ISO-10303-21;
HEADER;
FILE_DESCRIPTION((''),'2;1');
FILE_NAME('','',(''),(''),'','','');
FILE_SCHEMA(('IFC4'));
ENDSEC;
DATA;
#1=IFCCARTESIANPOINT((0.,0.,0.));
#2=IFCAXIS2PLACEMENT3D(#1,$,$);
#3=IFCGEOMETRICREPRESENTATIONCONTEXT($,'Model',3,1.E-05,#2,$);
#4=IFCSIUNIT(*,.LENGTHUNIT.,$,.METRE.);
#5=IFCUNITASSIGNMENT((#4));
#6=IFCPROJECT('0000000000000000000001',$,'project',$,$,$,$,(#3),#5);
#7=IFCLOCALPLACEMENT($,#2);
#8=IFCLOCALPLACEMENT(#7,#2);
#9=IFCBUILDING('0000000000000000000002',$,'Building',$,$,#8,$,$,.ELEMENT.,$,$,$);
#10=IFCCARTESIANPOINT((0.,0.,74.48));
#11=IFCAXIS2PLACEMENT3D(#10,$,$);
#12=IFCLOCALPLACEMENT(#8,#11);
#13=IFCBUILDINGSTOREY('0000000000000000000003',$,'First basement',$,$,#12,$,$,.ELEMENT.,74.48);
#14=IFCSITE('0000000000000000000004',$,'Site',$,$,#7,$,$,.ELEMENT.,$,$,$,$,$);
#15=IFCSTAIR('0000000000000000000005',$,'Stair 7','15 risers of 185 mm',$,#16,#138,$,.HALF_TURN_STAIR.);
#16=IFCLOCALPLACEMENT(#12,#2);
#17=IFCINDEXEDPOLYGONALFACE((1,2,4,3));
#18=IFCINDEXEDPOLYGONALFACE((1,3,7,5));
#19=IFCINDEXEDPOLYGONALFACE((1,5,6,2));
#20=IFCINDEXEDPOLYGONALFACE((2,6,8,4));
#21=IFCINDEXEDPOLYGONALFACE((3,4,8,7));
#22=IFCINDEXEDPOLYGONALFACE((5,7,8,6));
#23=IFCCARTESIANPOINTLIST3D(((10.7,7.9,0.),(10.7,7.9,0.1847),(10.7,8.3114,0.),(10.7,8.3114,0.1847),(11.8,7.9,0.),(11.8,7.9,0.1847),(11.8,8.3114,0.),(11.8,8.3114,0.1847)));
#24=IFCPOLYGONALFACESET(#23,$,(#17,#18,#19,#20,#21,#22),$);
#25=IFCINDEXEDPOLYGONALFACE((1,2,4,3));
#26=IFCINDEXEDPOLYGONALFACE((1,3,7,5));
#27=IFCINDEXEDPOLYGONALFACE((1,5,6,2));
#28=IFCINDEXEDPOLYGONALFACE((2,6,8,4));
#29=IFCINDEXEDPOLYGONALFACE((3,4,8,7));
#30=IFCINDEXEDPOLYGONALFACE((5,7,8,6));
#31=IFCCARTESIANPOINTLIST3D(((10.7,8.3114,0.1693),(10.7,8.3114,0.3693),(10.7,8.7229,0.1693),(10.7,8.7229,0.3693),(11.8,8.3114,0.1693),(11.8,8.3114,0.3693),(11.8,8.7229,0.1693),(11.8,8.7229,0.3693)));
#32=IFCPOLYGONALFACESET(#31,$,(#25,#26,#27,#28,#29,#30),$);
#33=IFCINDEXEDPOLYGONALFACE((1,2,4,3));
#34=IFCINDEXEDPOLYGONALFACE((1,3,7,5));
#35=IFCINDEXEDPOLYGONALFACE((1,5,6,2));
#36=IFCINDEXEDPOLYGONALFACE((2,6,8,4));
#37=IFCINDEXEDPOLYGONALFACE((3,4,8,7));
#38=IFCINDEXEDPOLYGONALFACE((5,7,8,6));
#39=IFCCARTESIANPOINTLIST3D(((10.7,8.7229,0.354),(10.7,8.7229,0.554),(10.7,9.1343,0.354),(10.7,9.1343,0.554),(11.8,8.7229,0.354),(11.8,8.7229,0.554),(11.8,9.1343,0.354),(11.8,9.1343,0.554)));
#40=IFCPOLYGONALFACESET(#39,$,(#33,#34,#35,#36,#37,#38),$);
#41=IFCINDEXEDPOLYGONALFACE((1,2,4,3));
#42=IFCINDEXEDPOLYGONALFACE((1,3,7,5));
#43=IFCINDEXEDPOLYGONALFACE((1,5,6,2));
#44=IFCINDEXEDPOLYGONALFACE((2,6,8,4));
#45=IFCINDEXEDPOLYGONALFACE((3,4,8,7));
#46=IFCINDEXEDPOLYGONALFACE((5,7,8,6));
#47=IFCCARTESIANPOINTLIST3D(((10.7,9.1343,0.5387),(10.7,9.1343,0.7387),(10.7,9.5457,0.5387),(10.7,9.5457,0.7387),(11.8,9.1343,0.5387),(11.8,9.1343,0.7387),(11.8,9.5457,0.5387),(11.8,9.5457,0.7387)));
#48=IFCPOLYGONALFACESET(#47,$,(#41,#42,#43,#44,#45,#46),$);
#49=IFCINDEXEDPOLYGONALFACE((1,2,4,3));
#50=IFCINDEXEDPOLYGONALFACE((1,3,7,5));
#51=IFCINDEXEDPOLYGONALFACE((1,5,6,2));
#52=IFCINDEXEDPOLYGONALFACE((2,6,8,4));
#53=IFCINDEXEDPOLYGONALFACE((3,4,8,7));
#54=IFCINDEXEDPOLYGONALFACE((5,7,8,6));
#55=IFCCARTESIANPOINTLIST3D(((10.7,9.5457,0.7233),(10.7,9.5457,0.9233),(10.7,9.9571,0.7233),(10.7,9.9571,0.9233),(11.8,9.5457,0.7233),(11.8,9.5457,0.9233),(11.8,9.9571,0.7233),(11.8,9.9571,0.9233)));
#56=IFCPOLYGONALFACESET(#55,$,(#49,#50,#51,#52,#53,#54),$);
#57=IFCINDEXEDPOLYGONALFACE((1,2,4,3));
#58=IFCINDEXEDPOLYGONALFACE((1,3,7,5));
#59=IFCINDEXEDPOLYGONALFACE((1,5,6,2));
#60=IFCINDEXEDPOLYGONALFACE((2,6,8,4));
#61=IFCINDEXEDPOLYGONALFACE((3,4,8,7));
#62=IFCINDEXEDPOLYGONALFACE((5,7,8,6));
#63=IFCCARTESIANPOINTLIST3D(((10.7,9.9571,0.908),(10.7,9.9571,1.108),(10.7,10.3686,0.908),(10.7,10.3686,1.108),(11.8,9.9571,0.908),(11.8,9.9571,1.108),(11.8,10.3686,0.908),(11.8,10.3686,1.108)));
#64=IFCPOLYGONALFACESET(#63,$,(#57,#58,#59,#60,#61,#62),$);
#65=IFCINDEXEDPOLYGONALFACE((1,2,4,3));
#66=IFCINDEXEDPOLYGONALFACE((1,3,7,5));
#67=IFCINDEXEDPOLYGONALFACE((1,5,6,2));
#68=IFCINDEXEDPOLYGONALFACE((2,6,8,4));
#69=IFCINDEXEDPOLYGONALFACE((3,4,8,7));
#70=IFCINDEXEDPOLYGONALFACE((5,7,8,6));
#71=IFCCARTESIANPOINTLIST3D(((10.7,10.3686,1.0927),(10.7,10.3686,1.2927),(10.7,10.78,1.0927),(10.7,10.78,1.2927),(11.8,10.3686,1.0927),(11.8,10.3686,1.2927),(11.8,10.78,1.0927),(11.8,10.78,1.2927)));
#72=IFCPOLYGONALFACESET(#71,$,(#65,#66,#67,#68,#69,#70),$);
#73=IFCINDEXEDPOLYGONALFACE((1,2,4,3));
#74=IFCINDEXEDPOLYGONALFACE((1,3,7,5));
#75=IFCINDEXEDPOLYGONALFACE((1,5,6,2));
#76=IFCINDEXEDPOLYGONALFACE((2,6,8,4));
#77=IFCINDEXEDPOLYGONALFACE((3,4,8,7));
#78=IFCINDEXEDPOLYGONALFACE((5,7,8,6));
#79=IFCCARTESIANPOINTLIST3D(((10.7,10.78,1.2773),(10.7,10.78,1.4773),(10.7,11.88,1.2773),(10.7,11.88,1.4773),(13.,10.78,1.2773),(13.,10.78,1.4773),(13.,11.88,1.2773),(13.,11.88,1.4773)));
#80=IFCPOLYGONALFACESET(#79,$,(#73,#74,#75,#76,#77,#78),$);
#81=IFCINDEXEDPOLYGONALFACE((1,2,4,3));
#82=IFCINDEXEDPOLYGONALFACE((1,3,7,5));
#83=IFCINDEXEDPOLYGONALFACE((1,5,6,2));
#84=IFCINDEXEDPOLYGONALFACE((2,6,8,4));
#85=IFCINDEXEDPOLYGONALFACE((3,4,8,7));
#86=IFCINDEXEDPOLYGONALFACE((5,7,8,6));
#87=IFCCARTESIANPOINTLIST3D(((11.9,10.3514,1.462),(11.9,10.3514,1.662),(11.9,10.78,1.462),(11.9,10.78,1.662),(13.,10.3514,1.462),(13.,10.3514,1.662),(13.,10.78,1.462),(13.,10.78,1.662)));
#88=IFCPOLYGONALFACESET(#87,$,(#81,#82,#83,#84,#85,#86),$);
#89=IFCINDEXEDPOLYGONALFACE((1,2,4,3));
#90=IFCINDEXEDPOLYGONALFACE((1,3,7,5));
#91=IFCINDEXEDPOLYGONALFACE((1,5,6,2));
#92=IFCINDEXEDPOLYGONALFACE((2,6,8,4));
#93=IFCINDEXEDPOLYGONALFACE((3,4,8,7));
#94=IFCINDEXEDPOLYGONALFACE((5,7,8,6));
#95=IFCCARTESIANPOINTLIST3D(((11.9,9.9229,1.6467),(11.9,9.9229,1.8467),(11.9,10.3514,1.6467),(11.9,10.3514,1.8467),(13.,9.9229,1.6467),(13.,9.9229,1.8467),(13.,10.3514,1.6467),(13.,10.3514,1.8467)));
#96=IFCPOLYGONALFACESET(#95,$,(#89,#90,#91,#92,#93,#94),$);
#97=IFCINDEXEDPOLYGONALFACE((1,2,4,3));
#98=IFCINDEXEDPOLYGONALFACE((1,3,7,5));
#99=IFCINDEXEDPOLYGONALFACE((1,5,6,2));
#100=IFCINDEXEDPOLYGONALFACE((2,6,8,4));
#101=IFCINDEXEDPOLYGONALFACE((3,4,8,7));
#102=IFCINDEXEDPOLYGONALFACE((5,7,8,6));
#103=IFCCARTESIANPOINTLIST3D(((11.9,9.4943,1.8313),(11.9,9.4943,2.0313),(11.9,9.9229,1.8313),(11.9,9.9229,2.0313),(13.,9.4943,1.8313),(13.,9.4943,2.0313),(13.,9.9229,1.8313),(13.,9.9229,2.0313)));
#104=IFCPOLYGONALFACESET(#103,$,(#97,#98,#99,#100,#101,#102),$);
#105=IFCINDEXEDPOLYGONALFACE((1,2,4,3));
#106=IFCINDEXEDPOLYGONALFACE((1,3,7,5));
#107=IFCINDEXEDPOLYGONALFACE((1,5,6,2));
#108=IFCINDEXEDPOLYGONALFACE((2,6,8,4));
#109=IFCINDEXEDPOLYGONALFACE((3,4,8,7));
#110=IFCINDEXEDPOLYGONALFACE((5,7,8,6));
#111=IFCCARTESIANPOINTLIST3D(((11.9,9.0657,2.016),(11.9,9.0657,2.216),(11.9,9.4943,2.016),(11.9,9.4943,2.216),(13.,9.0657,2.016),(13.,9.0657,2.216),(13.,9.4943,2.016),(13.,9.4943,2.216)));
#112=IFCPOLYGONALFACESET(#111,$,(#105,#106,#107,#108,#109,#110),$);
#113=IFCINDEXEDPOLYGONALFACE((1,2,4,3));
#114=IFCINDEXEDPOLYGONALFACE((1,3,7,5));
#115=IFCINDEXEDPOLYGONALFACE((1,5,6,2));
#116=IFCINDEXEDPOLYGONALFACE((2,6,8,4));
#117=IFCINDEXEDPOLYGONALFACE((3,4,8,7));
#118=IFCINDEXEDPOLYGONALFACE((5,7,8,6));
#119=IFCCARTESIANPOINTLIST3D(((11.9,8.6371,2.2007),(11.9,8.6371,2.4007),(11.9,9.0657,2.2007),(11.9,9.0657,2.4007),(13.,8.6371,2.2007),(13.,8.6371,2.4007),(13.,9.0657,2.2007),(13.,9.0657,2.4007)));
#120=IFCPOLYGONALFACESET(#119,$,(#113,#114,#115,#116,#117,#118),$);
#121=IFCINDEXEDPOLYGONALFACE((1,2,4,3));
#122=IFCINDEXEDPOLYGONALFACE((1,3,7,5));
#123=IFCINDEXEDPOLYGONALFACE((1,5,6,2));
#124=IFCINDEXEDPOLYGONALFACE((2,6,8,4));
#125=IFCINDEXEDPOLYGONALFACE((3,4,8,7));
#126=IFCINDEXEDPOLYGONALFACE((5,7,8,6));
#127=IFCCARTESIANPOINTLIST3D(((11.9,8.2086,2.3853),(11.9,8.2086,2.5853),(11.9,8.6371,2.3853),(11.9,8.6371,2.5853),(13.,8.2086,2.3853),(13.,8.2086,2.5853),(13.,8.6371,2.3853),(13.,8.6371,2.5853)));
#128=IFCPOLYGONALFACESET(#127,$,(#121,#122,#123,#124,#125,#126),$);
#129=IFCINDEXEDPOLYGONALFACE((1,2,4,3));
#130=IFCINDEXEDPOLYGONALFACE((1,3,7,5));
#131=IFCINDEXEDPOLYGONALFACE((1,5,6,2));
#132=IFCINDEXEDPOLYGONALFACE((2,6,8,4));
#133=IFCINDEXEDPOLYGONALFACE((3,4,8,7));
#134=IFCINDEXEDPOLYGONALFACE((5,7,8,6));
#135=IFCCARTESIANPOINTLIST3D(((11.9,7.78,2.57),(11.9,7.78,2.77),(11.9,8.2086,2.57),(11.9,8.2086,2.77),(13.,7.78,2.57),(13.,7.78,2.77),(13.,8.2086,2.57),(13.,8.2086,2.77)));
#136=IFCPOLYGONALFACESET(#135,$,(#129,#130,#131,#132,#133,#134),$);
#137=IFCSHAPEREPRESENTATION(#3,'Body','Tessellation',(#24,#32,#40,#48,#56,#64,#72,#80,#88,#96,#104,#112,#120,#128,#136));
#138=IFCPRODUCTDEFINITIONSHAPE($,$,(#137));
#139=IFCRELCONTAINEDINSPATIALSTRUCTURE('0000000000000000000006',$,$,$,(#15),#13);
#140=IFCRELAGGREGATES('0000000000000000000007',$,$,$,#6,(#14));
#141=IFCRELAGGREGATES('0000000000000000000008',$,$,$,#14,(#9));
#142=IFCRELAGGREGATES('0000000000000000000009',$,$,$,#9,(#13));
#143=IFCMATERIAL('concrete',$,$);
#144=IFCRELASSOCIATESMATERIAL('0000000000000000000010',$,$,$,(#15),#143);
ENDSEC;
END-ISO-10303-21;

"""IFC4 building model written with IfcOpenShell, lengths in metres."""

from ifc_helpers import new_model, si_unit, frame, origin, place, context, project, spatial, polyline, outline, extrude, material, element, save


model = new_model("IFC4")

# Units and contexts
model_context = context("Model", 3, precision=1e-05, world=origin())
ifc_project = project(units=[si_unit("LENGTHUNIT", "METRE")], contexts=[model_context])

# Site, building, storey
site_placement = place(None, origin())
site = spatial("IfcSite", under=ifc_project, at=site_placement, Name="Site", CompositionType="ELEMENT")
building_placement = place(site_placement, origin())
building = spatial("IfcBuilding", under=site, at=building_placement, Name="Building", CompositionType="ELEMENT")
storey_placement = place(building_placement, frame((0.0, 0.0, 74.48)))
storey = spatial("IfcBuildingStorey", under=building, at=storey_placement, Name="First basement", CompositionType="ELEMENT", Elevation=74.48)

# Shared definitions
ifc_material = material(Name="concrete")

# Stair
stair_1_placement = place(storey_placement, frame((11.25, 7.9, 0.0), z_axis=(0.0, 0.0, 1.0), x_axis=(0.0, 1.0, 0.0)))
element("IfcStair", 1, at=stair_1_placement, inside=storey, material=ifc_material, Name="Stair 7", Description="15 risers of 185 mm", PredefinedType="HALF_TURN_STAIR", context=model_context, shape_type="SweptSolid", body=[
    extrude(outline(polyline([(0.0, -0.55), (0.4114, -0.55), (0.4114, 0.55), (0.0, 0.55), (0.0, -0.55)])), origin(), (0.0, 0.0, 1.0), 0.1847),
    extrude(outline(polyline([(0.4114, -0.55), (0.8229, -0.55), (0.8229, 0.55), (0.4114, 0.55), (0.4114, -0.55)])), frame((0.0, 0.0, 0.1693)), (0.0, 0.0, 1.0), 0.2),
    extrude(outline(polyline([(0.8229, -0.55), (1.2343, -0.55), (1.2343, 0.55), (0.8229, 0.55), (0.8229, -0.55)])), frame((0.0, 0.0, 0.354)), (0.0, 0.0, 1.0), 0.2),
    extrude(outline(polyline([(1.2343, -0.55), (1.6457, -0.55), (1.6457, 0.55), (1.2343, 0.55), (1.2343, -0.55)])), frame((0.0, 0.0, 0.5387)), (0.0, 0.0, 1.0), 0.2),
    extrude(outline(polyline([(1.6457, -0.55), (2.0571, -0.55), (2.0571, 0.55), (1.6457, 0.55), (1.6457, -0.55)])), frame((0.0, 0.0, 0.7233)), (0.0, 0.0, 1.0), 0.2),
    extrude(outline(polyline([(2.0571, -0.55), (2.4686, -0.55), (2.4686, 0.55), (2.0571, 0.55), (2.0571, -0.55)])), frame((0.0, 0.0, 0.908)), (0.0, 0.0, 1.0), 0.2),
    extrude(outline(polyline([(2.4686, -0.55), (2.88, -0.55), (2.88, 0.55), (2.4686, 0.55), (2.4686, -0.55)])), frame((0.0, 0.0, 1.0927)), (0.0, 0.0, 1.0), 0.2),
    extrude(outline(polyline([(2.88, -1.75), (3.98, -1.75), (3.98, 0.55), (2.88, 0.55), (2.88, -1.75)])), frame((0.0, 0.0, 1.2773)), (0.0, 0.0, 1.0), 0.2),
    extrude(outline(polyline([(2.4514, -1.75), (2.88, -1.75), (2.88, -0.65), (2.4514, -0.65), (2.4514, -1.75)])), frame((0.0, 0.0, 1.462)), (0.0, 0.0, 1.0), 0.2),
    extrude(outline(polyline([(2.0229, -1.75), (2.4514, -1.75), (2.4514, -0.65), (2.0229, -0.65), (2.0229, -1.75)])), frame((0.0, 0.0, 1.6467)), (0.0, 0.0, 1.0), 0.2),
    extrude(outline(polyline([(1.5943, -1.75), (2.0229, -1.75), (2.0229, -0.65), (1.5943, -0.65), (1.5943, -1.75)])), frame((0.0, 0.0, 1.8313)), (0.0, 0.0, 1.0), 0.2),
    extrude(outline(polyline([(1.1657, -1.75), (1.5943, -1.75), (1.5943, -0.65), (1.1657, -0.65), (1.1657, -1.75)])), frame((0.0, 0.0, 2.016)), (0.0, 0.0, 1.0), 0.2),
    extrude(outline(polyline([(0.7371, -1.75), (1.1657, -1.75), (1.1657, -0.65), (0.7371, -0.65), (0.7371, -1.75)])), frame((0.0, 0.0, 2.2007)), (0.0, 0.0, 1.0), 0.2),
    extrude(outline(polyline([(0.3086, -1.75), (0.7371, -1.75), (0.7371, -0.65), (0.3086, -0.65), (0.3086, -1.75)])), frame((0.0, 0.0, 2.3853)), (0.0, 0.0, 1.0), 0.2),
    extrude(outline(polyline([(-0.12, -1.75), (0.3086, -1.75), (0.3086, -0.65), (-0.12, -0.65), (-0.12, -1.75)])), frame((0.0, 0.0, 2.57)), (0.0, 0.0, 1.0), 0.2),
])

save(model, "model.ifc")
